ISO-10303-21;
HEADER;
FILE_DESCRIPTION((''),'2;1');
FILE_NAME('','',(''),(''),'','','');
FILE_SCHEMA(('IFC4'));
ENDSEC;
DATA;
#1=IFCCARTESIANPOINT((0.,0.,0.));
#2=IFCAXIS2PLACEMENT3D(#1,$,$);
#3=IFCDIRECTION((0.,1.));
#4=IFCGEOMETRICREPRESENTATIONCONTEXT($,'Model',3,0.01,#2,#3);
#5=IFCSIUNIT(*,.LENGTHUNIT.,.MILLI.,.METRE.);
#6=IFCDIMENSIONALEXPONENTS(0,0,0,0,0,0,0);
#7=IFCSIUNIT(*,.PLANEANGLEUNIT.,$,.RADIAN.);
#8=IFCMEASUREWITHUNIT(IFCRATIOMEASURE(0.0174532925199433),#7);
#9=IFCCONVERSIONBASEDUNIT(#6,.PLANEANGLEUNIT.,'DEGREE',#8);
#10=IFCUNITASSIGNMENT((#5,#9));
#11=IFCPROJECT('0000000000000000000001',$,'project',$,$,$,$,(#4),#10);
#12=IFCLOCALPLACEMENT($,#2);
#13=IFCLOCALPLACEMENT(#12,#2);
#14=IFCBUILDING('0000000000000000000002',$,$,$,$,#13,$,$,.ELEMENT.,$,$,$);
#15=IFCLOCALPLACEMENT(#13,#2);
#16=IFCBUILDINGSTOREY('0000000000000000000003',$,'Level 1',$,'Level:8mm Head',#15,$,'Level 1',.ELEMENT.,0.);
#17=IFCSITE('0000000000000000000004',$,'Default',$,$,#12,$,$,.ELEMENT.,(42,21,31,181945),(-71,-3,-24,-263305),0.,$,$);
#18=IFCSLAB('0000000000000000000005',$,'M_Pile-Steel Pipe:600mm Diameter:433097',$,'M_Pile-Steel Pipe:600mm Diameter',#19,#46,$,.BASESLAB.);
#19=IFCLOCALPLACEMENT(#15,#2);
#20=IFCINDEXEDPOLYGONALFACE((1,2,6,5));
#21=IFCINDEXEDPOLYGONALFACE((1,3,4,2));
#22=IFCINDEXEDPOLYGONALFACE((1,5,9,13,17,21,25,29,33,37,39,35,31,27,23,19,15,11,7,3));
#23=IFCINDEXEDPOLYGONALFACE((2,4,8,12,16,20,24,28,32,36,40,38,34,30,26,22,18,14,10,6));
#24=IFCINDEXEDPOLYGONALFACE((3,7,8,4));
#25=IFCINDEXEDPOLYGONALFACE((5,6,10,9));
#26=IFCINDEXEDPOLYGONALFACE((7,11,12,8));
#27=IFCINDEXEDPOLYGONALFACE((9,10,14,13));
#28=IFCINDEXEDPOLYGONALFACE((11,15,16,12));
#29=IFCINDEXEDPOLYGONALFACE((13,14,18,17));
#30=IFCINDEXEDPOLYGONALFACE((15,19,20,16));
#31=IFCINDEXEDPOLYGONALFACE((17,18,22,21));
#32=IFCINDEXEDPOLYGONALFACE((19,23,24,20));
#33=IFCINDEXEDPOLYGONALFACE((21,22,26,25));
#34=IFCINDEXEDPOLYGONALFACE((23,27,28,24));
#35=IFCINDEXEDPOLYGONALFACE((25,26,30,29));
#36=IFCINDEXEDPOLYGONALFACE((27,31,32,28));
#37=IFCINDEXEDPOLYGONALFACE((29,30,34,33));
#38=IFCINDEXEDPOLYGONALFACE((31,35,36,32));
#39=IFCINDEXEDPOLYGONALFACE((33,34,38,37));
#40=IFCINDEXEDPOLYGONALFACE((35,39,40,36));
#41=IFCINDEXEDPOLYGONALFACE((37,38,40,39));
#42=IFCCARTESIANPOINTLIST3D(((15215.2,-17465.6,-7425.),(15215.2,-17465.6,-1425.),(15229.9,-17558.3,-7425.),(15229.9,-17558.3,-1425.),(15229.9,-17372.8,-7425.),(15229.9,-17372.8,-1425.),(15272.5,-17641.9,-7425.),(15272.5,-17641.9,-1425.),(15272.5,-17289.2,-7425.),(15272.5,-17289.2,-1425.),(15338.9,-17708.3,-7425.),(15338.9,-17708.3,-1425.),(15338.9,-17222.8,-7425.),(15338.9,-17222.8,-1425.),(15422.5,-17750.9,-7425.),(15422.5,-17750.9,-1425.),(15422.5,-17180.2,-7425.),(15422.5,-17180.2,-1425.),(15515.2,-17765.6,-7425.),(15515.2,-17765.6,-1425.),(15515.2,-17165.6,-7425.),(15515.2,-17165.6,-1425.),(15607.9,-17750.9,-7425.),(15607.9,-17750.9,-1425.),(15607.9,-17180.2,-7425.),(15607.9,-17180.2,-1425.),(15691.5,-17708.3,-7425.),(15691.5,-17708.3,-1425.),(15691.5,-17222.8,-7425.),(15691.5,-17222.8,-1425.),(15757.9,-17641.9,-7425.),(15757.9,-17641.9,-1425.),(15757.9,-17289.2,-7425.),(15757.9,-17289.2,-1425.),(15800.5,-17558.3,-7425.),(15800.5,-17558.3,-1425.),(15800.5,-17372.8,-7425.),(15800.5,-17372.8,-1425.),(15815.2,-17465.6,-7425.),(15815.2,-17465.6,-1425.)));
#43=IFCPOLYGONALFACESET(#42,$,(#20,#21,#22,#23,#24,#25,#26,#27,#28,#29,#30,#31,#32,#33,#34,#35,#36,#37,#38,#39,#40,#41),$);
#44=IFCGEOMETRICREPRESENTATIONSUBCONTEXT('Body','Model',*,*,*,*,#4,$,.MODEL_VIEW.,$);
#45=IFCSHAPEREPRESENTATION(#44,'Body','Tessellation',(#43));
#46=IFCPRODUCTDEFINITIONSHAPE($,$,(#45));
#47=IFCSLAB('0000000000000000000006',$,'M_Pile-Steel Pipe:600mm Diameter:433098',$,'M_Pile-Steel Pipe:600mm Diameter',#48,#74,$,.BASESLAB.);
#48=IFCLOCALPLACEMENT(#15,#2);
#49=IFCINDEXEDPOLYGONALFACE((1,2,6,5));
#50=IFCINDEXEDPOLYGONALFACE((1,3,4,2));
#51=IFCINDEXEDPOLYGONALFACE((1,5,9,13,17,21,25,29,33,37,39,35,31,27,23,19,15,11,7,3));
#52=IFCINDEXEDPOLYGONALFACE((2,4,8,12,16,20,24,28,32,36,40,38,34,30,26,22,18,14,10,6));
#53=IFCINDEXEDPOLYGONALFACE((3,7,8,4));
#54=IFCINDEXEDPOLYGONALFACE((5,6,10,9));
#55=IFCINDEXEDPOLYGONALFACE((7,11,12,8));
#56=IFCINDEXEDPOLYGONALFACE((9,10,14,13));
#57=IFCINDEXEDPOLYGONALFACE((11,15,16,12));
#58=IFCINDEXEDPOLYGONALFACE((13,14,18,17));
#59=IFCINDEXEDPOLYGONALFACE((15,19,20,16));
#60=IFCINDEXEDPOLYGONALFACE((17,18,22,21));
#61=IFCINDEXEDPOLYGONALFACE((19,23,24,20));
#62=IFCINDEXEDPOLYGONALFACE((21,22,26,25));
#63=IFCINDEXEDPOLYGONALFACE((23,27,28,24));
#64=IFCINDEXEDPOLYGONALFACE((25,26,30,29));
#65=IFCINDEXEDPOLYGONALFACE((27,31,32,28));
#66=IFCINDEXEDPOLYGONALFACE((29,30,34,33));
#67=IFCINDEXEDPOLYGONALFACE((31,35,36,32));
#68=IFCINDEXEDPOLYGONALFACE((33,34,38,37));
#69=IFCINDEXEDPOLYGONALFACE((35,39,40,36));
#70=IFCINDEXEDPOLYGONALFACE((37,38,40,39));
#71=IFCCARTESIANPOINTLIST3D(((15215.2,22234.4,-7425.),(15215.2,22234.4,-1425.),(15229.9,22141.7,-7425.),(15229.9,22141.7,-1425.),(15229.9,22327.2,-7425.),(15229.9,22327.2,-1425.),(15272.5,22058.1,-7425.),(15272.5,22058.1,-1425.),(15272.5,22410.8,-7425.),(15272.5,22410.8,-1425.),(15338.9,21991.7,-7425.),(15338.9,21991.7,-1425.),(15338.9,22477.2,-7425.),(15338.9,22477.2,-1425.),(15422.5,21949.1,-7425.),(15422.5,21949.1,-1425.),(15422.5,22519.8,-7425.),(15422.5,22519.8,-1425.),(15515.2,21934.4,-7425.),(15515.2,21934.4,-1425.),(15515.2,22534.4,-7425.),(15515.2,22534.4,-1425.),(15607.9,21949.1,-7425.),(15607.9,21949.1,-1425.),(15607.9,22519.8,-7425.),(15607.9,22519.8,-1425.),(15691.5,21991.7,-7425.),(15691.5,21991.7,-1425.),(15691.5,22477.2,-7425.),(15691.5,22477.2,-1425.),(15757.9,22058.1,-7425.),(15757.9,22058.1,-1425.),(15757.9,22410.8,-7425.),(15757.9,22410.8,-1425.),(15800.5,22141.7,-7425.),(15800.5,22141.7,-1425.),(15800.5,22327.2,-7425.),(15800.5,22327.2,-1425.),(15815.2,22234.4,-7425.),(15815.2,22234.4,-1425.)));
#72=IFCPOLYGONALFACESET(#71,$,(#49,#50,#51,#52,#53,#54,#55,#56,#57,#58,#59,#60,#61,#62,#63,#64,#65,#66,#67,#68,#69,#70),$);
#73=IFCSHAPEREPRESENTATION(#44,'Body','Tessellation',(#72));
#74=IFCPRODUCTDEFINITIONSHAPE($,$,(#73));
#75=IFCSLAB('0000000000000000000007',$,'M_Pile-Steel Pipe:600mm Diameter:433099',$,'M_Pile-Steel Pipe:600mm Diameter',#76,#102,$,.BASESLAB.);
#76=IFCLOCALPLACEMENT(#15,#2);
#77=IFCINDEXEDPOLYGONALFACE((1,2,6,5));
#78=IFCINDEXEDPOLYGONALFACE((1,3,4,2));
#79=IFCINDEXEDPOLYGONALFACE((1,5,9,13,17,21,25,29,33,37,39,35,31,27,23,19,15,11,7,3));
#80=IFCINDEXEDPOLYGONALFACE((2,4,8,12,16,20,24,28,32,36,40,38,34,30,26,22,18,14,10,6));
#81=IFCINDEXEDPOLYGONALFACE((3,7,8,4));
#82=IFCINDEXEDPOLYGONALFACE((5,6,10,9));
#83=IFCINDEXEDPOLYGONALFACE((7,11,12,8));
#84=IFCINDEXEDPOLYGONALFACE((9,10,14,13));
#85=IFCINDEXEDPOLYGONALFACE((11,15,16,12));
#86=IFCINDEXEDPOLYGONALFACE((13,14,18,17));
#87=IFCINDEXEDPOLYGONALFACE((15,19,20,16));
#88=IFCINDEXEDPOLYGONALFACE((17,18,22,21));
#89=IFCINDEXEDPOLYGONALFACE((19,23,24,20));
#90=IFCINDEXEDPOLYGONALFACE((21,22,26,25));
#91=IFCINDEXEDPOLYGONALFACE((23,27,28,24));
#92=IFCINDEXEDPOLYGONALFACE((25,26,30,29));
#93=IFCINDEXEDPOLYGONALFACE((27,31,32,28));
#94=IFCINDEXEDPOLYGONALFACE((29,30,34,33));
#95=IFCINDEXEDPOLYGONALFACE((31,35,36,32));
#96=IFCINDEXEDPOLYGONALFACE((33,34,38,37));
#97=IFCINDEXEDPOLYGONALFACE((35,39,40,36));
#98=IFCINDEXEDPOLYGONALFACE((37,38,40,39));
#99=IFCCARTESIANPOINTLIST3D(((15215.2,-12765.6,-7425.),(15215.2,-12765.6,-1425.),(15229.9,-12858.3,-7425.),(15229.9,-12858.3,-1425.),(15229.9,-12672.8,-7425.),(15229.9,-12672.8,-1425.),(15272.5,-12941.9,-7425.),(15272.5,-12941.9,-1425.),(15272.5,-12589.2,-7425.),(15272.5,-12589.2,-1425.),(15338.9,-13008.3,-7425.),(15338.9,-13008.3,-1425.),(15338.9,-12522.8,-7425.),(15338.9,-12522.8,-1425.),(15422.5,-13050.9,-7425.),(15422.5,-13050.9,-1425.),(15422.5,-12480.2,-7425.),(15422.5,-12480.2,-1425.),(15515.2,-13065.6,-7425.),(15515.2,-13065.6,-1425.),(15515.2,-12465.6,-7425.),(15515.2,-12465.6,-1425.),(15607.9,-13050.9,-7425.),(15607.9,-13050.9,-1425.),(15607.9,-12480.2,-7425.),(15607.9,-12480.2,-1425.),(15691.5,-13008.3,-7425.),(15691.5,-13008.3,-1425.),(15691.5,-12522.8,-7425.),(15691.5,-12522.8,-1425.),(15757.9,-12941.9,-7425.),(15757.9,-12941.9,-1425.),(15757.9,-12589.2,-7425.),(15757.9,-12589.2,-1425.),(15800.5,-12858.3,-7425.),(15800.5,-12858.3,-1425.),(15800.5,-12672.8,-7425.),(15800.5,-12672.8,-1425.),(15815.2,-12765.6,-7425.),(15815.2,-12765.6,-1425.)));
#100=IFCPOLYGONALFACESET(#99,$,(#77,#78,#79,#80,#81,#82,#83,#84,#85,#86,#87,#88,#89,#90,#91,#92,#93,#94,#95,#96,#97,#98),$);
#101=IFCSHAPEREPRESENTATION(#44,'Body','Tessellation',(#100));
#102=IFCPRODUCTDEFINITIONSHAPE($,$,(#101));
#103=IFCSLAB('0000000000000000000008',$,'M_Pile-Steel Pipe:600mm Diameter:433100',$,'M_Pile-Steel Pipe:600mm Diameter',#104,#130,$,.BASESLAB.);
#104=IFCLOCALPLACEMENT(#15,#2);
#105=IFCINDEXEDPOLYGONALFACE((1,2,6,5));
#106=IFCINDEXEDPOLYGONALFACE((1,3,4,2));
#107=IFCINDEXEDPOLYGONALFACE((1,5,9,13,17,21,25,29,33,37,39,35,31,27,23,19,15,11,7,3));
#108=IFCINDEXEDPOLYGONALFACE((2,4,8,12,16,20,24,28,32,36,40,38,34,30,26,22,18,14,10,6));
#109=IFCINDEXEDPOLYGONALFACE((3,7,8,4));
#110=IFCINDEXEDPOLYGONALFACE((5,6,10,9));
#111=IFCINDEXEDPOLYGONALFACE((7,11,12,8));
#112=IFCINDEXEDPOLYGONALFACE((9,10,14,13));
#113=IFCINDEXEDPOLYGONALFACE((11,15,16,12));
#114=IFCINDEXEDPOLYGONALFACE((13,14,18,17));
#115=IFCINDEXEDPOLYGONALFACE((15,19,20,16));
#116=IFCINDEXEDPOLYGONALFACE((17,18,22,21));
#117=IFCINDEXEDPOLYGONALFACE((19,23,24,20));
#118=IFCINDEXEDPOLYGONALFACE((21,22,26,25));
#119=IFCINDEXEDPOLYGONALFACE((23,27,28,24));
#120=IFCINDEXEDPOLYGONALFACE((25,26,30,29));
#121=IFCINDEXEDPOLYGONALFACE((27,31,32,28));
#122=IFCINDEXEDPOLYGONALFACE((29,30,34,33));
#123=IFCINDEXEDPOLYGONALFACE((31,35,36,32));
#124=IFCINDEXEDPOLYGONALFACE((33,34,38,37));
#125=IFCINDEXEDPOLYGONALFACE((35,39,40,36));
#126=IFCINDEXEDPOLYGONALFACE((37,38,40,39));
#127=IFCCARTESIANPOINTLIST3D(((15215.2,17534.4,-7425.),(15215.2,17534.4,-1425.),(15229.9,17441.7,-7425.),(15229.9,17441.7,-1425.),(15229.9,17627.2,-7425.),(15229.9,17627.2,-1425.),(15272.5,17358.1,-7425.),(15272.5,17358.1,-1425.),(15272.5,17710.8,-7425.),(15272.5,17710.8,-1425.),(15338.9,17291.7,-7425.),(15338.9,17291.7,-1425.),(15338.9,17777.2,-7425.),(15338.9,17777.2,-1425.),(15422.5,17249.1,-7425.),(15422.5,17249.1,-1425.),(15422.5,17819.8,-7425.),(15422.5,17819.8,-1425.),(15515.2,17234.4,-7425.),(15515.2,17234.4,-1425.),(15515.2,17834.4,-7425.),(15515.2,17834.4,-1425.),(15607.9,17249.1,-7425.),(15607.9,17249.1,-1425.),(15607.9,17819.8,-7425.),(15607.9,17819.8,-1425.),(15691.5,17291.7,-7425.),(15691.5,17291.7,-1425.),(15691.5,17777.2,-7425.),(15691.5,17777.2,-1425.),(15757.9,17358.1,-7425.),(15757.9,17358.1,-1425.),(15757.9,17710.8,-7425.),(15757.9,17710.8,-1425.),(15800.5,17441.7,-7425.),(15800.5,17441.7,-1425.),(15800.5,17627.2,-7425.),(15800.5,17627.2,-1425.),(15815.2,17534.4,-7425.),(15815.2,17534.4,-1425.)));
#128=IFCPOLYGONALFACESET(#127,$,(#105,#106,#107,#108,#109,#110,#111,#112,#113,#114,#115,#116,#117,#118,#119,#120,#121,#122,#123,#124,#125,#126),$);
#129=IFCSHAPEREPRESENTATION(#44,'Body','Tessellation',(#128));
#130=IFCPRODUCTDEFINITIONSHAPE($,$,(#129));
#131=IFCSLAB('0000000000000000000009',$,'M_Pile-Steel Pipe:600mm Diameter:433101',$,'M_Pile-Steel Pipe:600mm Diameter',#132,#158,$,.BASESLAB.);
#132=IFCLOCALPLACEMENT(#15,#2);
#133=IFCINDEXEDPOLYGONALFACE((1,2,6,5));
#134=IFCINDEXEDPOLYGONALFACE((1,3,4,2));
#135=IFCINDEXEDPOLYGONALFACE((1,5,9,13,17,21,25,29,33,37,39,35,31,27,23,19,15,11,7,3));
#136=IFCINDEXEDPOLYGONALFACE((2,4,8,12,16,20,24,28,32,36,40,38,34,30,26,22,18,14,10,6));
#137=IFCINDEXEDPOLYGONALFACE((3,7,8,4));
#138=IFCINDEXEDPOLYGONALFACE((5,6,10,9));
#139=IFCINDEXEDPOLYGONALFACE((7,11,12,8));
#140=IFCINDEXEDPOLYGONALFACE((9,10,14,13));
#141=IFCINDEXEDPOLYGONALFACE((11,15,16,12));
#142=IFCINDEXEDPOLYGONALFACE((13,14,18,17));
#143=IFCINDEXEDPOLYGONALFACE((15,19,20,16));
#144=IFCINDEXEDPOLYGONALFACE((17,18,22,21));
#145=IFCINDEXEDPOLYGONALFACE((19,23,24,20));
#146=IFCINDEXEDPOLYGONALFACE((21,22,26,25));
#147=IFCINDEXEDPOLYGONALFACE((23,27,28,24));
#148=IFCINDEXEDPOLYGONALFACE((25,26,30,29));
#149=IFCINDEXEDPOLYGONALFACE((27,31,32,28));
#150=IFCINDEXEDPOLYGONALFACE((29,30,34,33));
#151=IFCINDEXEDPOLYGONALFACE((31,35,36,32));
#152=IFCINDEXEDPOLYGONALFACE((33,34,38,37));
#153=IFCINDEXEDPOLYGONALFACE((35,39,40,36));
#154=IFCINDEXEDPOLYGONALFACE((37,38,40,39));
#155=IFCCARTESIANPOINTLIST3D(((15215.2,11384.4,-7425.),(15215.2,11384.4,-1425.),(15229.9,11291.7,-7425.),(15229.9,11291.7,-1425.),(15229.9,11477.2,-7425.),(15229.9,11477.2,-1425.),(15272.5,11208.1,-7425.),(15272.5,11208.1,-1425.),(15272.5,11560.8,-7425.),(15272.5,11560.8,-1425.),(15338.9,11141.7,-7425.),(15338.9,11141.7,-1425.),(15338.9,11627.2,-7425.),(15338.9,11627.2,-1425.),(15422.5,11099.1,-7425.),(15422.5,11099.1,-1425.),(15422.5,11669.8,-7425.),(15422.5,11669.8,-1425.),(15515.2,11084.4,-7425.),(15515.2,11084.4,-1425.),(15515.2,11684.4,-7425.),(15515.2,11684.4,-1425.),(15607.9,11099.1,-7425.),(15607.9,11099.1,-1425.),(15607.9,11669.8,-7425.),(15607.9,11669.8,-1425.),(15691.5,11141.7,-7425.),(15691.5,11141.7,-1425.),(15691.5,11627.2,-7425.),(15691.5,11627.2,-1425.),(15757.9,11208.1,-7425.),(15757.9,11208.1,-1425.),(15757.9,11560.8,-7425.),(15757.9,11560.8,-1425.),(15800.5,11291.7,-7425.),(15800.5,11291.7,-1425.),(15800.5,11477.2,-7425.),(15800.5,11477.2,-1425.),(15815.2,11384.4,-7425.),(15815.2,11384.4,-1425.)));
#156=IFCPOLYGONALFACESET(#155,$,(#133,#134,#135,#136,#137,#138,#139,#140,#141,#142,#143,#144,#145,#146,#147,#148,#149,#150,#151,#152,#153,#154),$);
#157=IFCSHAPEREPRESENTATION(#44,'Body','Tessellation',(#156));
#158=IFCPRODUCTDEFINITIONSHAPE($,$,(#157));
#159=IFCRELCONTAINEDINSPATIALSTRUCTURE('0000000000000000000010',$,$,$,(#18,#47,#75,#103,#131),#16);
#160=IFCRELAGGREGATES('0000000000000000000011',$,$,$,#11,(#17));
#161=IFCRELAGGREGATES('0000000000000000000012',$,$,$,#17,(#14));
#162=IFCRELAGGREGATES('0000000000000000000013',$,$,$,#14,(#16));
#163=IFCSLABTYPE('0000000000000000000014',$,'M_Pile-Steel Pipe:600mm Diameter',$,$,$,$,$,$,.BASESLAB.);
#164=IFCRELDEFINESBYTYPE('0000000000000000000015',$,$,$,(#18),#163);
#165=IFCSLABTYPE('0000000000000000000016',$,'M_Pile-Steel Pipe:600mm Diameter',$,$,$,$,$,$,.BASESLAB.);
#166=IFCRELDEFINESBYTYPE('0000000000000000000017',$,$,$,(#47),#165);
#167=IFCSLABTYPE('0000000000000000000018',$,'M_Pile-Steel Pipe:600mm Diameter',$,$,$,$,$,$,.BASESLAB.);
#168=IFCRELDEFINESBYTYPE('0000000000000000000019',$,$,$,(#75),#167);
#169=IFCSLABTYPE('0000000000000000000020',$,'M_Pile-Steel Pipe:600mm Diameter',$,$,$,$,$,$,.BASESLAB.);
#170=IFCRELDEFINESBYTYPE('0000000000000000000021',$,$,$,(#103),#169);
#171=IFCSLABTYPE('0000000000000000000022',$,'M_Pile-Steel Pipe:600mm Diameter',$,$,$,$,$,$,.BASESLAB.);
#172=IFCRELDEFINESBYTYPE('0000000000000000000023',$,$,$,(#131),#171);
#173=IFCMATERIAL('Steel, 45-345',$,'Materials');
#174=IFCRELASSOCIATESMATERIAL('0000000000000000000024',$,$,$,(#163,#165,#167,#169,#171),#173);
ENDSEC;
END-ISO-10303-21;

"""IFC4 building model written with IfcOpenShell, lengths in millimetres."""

from ifc_helpers import new_model, entity, si_unit, converted_unit, direction, frame, origin, place, context, subcontext, project, spatial, indexed_curve, outline, extrude, material, type_object, element, save


model = new_model("IFC4")

# Units and contexts
model_context = context("Model", 3, precision=0.01, world=origin(), true_north=direction((0.0, 1.0)))
body_context = subcontext(model_context, "Body", "Model", "MODEL_VIEW")
ifc_project = project(units=[si_unit("LENGTHUNIT", "METRE", prefix="MILLI"), converted_unit("PLANEANGLEUNIT", "DEGREE", entity("IfcRatioMeasure", 0.0174532925199433), si_unit("PLANEANGLEUNIT", "RADIAN"), dimensions=[0, 0, 0, 0, 0, 0, 0])], contexts=[model_context])

# Site, building, storey
site_placement = place(None, origin())
site = spatial("IfcSite", under=ifc_project, at=site_placement, Name="Default", CompositionType="ELEMENT", RefLatitude=(42, 21, 31, 181945), RefLongitude=(-71, -3, -24, -263305), RefElevation=0.0)
building_placement = place(site_placement, origin())
building = spatial("IfcBuilding", under=site, at=building_placement, CompositionType="ELEMENT")
storey_placement = place(building_placement, origin())
storey = spatial("IfcBuildingStorey", under=building, at=storey_placement, Name="Level 1", ObjectType="Level:8mm Head", LongName="Level 1", CompositionType="ELEMENT", Elevation=0.0)

# Slabs
ifc_material_1 = material(Name="Steel, 45-345", Category="Materials")
slab_type_1 = type_object("IfcSlabType", Name="M_Pile-Steel Pipe:600mm Diameter", PredefinedType="BASESLAB", material=ifc_material_1)
slab_1_placement = place(building_placement, origin())
element("IfcSlab", 1, at=slab_1_placement, inside=storey, type_object=slab_type_1, Name="M_Pile-Steel Pipe:600mm Diameter:433097", ObjectType="M_Pile-Steel Pipe:600mm Diameter", PredefinedType="BASESLAB", context=body_context, shape_type="SweptSolid", body=[
    extrude(outline(indexed_curve([(300.0, 0.0), (285.3, 92.7), (242.7, 176.3), (176.3, 242.7), (92.7, 285.3), (0.0, 300.0), (-92.7, 285.3), (-176.3, 242.7), (-242.7, 176.3), (-285.3, 92.7), (-300.0, 0.0), (-285.3, -92.7), (-242.7, -176.3), (-176.3, -242.7), (-92.7, -285.3), (0.0, -300.0), (92.7, -285.3), (176.3, -242.7), (242.7, -176.3), (285.3, -92.7), (300.0, 0.0)], self_intersect=False)), frame((15515.2, -17465.6, -7425.0)), (0.0, 0.0, 1.0), 6000.0),
])
slab_type_2 = type_object("IfcSlabType", Name="M_Pile-Steel Pipe:600mm Diameter", PredefinedType="BASESLAB", material=ifc_material_1)
slab_2_placement = place(building_placement, origin())
element("IfcSlab", 2, at=slab_2_placement, inside=storey, type_object=slab_type_2, Name="M_Pile-Steel Pipe:600mm Diameter:433098", ObjectType="M_Pile-Steel Pipe:600mm Diameter", PredefinedType="BASESLAB", context=body_context, shape_type="SweptSolid", body=[
    extrude(outline(indexed_curve([(300.0, 0.0), (285.3, 92.7), (242.7, 176.3), (176.3, 242.7), (92.7, 285.3), (0.0, 300.0), (-92.7, 285.3), (-176.3, 242.7), (-242.7, 176.3), (-285.3, 92.7), (-300.0, 0.0), (-285.3, -92.7), (-242.7, -176.3), (-176.3, -242.7), (-92.7, -285.3), (0.0, -300.0), (92.7, -285.3), (176.3, -242.7), (242.7, -176.3), (285.3, -92.7), (300.0, 0.0)], self_intersect=False)), frame((15515.2, 22234.4, -7425.0)), (0.0, 0.0, 1.0), 6000.0),
])
slab_type_3 = type_object("IfcSlabType", Name="M_Pile-Steel Pipe:600mm Diameter", PredefinedType="BASESLAB", material=ifc_material_1)
slab_3_placement = place(building_placement, origin())
element("IfcSlab", 3, at=slab_3_placement, inside=storey, type_object=slab_type_3, Name="M_Pile-Steel Pipe:600mm Diameter:433099", ObjectType="M_Pile-Steel Pipe:600mm Diameter", PredefinedType="BASESLAB", context=body_context, shape_type="SweptSolid", body=[
    extrude(outline(indexed_curve([(300.0, 0.0), (285.3, 92.7), (242.7, 176.3), (176.3, 242.7), (92.7, 285.3), (0.0, 300.0), (-92.7, 285.3), (-176.3, 242.7), (-242.7, 176.3), (-285.3, 92.7), (-300.0, 0.0), (-285.3, -92.7), (-242.7, -176.3), (-176.3, -242.7), (-92.7, -285.3), (0.0, -300.0), (92.7, -285.3), (176.3, -242.7), (242.7, -176.3), (285.3, -92.7), (300.0, 0.0)], self_intersect=False)), frame((15515.2, -12765.6, -7425.0)), (0.0, 0.0, 1.0), 6000.0),
])
slab_type_4 = type_object("IfcSlabType", Name="M_Pile-Steel Pipe:600mm Diameter", PredefinedType="BASESLAB", material=ifc_material_1)
slab_4_placement = place(building_placement, origin())
element("IfcSlab", 4, at=slab_4_placement, inside=storey, type_object=slab_type_4, Name="M_Pile-Steel Pipe:600mm Diameter:433100", ObjectType="M_Pile-Steel Pipe:600mm Diameter", PredefinedType="BASESLAB", context=body_context, shape_type="SweptSolid", body=[
    extrude(outline(indexed_curve([(300.0, 0.0), (285.3, 92.7), (242.7, 176.3), (176.3, 242.7), (92.7, 285.3), (0.0, 300.0), (-92.7, 285.3), (-176.3, 242.7), (-242.7, 176.3), (-285.3, 92.7), (-300.0, 0.0), (-285.3, -92.7), (-242.7, -176.3), (-176.3, -242.7), (-92.7, -285.3), (0.0, -300.0), (92.7, -285.3), (176.3, -242.7), (242.7, -176.3), (285.3, -92.7), (300.0, 0.0)], self_intersect=False)), frame((15515.2, 17534.4, -7425.0)), (0.0, 0.0, 1.0), 6000.0),
])
slab_type_5 = type_object("IfcSlabType", Name="M_Pile-Steel Pipe:600mm Diameter", PredefinedType="BASESLAB", material=ifc_material_1)
slab_5_placement = place(building_placement, origin())
element("IfcSlab", 5, at=slab_5_placement, inside=storey, type_object=slab_type_5, Name="M_Pile-Steel Pipe:600mm Diameter:433101", ObjectType="M_Pile-Steel Pipe:600mm Diameter", PredefinedType="BASESLAB", context=body_context, shape_type="SweptSolid", body=[
    extrude(outline(indexed_curve([(300.0, 0.0), (285.3, 92.7), (242.7, 176.3), (176.3, 242.7), (92.7, 285.3), (0.0, 300.0), (-92.7, 285.3), (-176.3, 242.7), (-242.7, 176.3), (-285.3, 92.7), (-300.0, 0.0), (-285.3, -92.7), (-242.7, -176.3), (-176.3, -242.7), (-92.7, -285.3), (0.0, -300.0), (92.7, -285.3), (176.3, -242.7), (242.7, -176.3), (285.3, -92.7), (300.0, 0.0)], self_intersect=False)), frame((15515.2, 11384.4, -7425.0)), (0.0, 0.0, 1.0), 6000.0),
])

save(model, "model.ifc")
